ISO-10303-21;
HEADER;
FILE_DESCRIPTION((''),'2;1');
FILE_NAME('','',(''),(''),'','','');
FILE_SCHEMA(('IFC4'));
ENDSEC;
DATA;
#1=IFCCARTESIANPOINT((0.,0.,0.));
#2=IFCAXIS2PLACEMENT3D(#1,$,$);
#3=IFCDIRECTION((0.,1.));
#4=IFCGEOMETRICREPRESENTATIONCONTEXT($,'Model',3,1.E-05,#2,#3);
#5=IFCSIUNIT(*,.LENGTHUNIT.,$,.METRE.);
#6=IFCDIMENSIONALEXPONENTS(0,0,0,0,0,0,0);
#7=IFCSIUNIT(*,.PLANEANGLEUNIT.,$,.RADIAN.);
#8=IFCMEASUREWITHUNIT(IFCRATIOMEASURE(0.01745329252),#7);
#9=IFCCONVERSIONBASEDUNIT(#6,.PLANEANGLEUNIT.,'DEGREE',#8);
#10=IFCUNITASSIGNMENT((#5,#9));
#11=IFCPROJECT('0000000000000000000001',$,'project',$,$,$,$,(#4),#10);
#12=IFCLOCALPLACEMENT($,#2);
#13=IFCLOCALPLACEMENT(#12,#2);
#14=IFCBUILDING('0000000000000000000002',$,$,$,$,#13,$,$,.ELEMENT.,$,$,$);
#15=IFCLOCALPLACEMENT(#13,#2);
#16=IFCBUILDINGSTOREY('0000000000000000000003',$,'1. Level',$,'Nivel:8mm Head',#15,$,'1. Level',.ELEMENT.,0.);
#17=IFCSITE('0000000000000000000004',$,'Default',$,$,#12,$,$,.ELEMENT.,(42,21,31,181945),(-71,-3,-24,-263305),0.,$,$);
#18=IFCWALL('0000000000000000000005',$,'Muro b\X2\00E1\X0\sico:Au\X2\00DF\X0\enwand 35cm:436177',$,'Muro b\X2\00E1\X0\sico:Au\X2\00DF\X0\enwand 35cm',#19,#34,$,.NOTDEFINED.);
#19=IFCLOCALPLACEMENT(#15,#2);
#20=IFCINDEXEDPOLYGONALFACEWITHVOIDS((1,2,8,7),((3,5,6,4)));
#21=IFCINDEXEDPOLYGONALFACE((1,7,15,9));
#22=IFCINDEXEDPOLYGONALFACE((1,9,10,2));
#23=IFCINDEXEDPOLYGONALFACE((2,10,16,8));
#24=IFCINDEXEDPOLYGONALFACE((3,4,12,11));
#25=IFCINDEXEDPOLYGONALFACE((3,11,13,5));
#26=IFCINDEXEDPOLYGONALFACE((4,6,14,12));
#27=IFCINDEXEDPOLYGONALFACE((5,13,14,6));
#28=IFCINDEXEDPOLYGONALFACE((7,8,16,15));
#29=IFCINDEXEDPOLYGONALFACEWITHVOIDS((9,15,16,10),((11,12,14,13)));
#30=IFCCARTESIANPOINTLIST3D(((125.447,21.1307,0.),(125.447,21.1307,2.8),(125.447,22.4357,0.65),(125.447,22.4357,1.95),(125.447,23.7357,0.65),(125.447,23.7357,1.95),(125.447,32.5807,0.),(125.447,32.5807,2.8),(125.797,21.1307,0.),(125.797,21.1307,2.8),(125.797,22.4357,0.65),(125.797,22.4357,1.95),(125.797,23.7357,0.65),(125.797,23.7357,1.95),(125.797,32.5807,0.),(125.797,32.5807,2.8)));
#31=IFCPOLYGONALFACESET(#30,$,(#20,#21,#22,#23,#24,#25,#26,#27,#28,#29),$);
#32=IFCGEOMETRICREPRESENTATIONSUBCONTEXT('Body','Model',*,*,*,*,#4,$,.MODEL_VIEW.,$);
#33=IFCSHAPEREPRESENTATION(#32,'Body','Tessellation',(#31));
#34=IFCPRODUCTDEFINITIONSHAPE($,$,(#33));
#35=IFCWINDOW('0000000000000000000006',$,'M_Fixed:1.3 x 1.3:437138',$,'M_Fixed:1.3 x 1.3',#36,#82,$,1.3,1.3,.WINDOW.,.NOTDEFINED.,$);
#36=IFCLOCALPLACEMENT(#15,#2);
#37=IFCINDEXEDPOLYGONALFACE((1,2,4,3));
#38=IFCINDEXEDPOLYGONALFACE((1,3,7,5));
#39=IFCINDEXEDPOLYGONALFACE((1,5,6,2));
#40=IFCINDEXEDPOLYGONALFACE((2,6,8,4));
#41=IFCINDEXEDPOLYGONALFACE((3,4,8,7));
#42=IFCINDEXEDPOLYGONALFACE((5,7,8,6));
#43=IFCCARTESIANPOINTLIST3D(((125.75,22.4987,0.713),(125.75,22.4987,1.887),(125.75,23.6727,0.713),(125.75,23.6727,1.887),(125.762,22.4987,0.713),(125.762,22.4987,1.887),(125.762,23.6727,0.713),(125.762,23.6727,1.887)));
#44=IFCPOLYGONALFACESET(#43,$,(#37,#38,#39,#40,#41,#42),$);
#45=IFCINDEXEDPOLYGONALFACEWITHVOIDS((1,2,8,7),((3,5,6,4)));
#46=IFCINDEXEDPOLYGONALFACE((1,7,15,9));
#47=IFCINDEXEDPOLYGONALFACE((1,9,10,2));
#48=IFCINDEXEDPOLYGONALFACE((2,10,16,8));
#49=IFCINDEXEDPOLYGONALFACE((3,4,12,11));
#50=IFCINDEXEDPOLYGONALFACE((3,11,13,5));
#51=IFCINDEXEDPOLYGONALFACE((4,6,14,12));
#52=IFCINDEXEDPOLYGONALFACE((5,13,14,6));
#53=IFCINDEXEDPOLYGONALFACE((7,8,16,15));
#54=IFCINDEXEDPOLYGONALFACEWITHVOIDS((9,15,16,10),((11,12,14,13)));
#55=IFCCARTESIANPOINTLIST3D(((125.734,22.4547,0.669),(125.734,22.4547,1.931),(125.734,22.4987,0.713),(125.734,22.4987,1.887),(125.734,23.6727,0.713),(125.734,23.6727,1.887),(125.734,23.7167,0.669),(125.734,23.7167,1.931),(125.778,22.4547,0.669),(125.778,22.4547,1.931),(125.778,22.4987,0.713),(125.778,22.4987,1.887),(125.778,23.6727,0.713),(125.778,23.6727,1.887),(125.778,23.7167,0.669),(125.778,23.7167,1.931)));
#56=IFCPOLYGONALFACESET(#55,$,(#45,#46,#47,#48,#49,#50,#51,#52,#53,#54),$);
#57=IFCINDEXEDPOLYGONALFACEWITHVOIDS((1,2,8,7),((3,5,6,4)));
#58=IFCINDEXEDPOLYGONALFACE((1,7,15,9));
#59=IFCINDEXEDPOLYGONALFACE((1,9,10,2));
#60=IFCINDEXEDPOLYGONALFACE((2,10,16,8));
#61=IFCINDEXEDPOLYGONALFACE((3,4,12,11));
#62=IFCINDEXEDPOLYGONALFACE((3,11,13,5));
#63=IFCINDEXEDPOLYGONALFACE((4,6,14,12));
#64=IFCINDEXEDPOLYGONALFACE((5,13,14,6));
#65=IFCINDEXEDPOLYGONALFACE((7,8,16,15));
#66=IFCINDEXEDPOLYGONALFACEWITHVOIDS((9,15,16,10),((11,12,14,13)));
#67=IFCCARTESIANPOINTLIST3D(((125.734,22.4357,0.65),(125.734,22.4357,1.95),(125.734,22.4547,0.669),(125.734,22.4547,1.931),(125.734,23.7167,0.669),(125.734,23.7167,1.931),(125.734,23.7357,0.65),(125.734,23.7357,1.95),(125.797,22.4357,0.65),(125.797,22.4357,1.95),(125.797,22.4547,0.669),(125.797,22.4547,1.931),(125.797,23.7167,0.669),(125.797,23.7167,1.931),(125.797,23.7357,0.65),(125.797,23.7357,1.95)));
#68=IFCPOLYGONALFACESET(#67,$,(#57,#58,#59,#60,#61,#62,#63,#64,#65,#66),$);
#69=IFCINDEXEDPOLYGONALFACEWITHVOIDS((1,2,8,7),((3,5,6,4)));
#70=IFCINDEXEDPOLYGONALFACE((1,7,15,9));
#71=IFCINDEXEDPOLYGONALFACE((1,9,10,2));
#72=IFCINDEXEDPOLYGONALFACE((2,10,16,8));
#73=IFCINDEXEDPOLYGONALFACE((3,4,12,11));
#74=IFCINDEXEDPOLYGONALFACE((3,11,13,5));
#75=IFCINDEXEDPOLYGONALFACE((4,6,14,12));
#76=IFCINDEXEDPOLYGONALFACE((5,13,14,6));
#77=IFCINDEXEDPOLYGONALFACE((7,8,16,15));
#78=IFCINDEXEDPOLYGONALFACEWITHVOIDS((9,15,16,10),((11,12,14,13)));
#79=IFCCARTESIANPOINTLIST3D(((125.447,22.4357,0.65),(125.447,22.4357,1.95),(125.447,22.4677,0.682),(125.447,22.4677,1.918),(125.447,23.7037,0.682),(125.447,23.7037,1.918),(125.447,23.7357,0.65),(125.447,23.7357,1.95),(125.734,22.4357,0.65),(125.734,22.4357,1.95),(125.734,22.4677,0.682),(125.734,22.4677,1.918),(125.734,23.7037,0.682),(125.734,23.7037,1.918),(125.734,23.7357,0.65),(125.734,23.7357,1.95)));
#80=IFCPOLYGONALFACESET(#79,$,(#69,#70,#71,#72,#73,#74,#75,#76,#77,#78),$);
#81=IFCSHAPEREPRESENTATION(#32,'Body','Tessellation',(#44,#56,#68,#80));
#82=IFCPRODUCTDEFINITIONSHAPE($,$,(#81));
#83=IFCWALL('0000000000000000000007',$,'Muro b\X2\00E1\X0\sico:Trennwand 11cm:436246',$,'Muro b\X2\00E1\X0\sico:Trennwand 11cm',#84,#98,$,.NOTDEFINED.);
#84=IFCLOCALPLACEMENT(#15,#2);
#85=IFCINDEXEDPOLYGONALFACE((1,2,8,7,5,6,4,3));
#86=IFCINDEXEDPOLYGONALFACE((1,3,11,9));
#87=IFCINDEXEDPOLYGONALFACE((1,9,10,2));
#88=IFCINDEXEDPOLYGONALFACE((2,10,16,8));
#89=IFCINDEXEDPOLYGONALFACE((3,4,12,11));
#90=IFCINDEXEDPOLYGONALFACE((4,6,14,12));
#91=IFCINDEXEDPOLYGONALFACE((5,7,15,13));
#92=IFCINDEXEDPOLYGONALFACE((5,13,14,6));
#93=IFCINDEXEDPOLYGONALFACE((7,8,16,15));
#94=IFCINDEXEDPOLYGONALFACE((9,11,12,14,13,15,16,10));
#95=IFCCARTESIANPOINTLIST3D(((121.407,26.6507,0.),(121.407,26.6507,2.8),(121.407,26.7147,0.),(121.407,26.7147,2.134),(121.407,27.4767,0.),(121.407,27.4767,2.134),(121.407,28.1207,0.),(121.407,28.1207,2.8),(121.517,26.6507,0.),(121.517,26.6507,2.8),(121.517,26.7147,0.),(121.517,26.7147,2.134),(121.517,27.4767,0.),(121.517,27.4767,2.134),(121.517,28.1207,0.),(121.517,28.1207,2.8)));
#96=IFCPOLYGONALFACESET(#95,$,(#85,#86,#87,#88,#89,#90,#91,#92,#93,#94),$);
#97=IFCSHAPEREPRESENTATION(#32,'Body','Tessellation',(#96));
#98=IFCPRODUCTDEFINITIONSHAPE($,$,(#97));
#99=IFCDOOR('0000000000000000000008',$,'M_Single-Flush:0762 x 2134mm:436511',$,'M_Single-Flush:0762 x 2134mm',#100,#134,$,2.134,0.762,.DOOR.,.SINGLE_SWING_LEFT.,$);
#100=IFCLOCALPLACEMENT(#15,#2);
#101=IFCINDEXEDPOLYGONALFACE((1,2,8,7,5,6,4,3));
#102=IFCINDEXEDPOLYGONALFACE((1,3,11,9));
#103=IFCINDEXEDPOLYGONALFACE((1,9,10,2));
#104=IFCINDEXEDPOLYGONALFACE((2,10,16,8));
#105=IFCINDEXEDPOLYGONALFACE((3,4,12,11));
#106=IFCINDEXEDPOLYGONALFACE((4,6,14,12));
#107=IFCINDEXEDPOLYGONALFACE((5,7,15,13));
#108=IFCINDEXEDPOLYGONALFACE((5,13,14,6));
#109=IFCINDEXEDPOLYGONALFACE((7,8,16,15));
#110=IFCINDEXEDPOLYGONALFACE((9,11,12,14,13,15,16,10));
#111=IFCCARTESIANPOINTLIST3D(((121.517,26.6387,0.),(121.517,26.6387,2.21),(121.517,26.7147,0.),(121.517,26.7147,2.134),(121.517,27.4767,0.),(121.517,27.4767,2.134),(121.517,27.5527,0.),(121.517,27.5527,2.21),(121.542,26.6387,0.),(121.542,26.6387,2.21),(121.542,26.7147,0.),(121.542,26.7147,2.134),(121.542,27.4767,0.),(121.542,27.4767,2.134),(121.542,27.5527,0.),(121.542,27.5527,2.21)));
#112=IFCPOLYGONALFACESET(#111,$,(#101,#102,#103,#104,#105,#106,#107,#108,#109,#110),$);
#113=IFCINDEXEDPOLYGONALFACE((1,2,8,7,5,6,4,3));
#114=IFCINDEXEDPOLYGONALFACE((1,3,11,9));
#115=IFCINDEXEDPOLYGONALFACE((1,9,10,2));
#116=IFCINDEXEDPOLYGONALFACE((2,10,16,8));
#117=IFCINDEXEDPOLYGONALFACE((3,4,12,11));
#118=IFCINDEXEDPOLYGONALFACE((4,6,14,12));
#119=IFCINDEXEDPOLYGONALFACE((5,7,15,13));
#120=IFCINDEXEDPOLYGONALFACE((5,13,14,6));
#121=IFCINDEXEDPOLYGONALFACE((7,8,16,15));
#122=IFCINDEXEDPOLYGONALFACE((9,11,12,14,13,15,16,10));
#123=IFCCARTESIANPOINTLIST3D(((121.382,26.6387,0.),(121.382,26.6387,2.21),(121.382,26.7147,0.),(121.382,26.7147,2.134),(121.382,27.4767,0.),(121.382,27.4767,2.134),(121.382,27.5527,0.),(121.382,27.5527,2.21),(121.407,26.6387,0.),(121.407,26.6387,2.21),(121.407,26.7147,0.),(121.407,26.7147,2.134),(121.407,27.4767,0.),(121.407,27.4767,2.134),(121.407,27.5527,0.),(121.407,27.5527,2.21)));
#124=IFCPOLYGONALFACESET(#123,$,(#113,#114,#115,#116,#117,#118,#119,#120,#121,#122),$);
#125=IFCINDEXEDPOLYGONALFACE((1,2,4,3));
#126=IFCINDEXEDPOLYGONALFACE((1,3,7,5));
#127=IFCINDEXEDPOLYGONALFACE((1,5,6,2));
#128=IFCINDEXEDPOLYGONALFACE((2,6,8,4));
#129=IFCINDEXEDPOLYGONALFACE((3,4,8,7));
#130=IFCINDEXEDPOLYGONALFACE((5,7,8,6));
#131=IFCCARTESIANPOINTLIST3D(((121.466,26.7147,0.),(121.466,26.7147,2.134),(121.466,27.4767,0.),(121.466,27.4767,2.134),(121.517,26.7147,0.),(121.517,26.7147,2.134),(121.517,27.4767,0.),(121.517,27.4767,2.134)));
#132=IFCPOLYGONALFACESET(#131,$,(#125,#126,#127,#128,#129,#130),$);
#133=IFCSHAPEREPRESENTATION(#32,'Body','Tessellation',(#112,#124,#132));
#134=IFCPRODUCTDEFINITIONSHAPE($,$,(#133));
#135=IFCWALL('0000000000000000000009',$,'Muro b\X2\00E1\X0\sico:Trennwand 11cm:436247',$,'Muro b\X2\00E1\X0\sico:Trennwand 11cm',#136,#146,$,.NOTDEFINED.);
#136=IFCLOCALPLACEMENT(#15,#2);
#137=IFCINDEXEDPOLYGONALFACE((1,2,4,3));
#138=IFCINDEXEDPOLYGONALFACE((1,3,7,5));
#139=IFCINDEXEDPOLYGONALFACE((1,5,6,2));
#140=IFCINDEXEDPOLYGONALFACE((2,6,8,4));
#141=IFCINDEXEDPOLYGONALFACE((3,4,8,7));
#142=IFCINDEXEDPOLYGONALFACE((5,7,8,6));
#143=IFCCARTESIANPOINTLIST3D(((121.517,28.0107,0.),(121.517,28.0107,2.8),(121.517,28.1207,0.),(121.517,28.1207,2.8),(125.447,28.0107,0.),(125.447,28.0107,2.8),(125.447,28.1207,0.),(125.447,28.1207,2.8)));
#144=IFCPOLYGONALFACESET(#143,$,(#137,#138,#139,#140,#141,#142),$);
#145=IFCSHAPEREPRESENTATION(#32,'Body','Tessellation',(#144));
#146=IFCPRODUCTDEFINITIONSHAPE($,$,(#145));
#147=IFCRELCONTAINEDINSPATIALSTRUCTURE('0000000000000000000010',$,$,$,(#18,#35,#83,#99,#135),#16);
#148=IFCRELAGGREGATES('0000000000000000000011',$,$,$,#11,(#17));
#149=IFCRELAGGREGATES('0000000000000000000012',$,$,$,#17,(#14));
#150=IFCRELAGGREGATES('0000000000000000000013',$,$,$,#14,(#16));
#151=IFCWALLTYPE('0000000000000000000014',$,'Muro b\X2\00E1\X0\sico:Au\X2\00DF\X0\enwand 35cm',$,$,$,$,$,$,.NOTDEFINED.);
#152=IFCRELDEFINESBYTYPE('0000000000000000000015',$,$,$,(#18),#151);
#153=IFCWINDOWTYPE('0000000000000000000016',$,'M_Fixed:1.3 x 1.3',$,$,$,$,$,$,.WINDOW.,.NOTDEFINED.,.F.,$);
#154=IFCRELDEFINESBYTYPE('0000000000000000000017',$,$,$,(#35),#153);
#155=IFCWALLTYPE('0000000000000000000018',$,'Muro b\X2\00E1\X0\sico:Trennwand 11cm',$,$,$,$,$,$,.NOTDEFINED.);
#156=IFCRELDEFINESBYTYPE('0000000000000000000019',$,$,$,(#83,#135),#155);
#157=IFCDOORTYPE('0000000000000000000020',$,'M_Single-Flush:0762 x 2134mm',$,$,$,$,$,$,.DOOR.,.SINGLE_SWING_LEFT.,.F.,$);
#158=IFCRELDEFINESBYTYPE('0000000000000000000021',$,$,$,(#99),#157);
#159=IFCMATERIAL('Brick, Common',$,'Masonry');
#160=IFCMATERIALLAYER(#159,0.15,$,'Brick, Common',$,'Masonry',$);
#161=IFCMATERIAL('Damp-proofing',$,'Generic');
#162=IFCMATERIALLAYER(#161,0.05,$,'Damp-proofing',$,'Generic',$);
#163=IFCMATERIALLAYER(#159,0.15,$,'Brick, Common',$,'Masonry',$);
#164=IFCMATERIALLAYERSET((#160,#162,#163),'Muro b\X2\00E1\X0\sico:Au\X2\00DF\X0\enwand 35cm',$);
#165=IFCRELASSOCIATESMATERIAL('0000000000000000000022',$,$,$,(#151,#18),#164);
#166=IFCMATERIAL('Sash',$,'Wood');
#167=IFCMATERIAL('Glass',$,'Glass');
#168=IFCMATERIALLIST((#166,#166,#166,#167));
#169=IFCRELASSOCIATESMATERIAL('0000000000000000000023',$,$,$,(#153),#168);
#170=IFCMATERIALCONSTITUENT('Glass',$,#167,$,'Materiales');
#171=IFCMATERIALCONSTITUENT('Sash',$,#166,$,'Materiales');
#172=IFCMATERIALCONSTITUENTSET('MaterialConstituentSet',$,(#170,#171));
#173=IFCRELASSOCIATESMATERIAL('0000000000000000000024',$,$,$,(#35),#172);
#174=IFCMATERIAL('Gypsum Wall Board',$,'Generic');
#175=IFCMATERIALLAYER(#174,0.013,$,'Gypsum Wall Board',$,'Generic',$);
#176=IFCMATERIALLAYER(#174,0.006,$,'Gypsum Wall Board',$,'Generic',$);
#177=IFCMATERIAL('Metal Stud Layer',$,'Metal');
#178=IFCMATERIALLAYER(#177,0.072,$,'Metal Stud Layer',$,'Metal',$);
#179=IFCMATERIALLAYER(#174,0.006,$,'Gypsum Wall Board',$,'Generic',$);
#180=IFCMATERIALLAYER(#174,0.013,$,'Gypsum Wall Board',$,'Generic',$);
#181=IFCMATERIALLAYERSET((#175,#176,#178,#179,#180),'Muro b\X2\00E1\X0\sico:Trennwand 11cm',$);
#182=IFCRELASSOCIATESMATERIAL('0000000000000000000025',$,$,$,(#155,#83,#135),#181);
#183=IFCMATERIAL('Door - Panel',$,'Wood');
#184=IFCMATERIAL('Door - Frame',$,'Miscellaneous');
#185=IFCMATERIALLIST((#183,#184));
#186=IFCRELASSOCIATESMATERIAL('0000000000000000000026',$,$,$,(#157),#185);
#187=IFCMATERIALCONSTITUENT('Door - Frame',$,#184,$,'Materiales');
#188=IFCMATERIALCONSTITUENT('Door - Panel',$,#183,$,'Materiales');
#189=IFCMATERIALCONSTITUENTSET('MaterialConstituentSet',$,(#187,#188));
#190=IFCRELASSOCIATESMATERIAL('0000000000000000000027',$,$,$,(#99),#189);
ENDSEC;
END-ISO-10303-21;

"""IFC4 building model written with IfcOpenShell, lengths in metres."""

from ifc_helpers import new_model, entity, si_unit, converted_unit, direction, frame, frame_2d, origin, origin_2d_with_axis, place, context, subcontext, project, spatial, polyline, rectangle, outline, extrude, source, transform, mapped, material, material_list, layer, layer_set, layer_usage, constituent, constituent_set, type_object, type_shapes, element, fill, save


model = new_model("IFC4")

# Units and contexts
model_context = context("Model", 3, precision=1e-05, world=origin(), true_north=direction((0.0, 1.0)))
body_context = subcontext(model_context, "Body", "Model", "MODEL_VIEW")
ifc_project = project(units=[si_unit("LENGTHUNIT", "METRE"), converted_unit("PLANEANGLEUNIT", "DEGREE", entity("IfcRatioMeasure", 0.01745329252), si_unit("PLANEANGLEUNIT", "RADIAN"), dimensions=[0, 0, 0, 0, 0, 0, 0])], contexts=[model_context])

# Site, building, storey
site_placement = place(None, origin())
site = spatial("IfcSite", under=ifc_project, at=site_placement, Name="Default", CompositionType="ELEMENT", RefLatitude=(42, 21, 31, 181945), RefLongitude=(-71, -3, -24, -263305), RefElevation=0.0)
building_placement = place(site_placement, origin())
building = spatial("IfcBuilding", under=site, at=building_placement, CompositionType="ELEMENT")
storey_placement = place(building_placement, origin())
storey = spatial("IfcBuildingStorey", under=building, at=storey_placement, Name="1. Level", ObjectType="Nivel:8mm Head", LongName="1. Level", CompositionType="ELEMENT", Elevation=0.0)

# Wall, opening, window
ifc_material_1 = material(Name="Brick, Common", Category="Masonry")
ifc_layer_1 = layer(ifc_material_1, 0.15, Name="Brick, Common", Category="Masonry")
ifc_material_2 = material(Name="Damp-proofing", Category="Generic")
ifc_layer_2 = layer(ifc_material_2, 0.05, Name="Damp-proofing", Category="Generic")
ifc_layer_3 = layer(ifc_material_1, 0.15, Name="Brick, Common", Category="Masonry")
ifc_layer_set_1 = layer_set([ifc_layer_1, ifc_layer_2, ifc_layer_3], Name="Muro básico:Außenwand 35cm")
ifc_layer_usage_1 = layer_usage(ifc_layer_set_1, "AXIS2", "NEGATIVE", 0.175)
wall_type_1 = type_object("IfcWallType", Name="Muro básico:Außenwand 35cm", PredefinedType="NOTDEFINED", material=ifc_layer_set_1)
wall_1_placement = place(storey_placement, frame((125.622, 21.1307, 0.0), z_axis=(0.0, 0.0, 1.0), x_axis=(0.0, 1.0, 0.0)))
wall_1 = element("IfcWall", 1, at=wall_1_placement, inside=storey, type_object=wall_type_1, material=ifc_layer_usage_1, Name="Muro básico:Außenwand 35cm:436177", ObjectType="Muro básico:Außenwand 35cm", PredefinedType="NOTDEFINED", context=body_context, shape_type="SweptSolid", body=[
    extrude(rectangle(XDim=11.45, YDim=0.35, at=frame_2d((5.725, 0.0), x_axis=(-1.0, 0.0))), origin(), (0.0, 0.0, 1.0), 2.8),
])
opening_1_placement = place(wall_1_placement, frame((2.605, 0.175, 0.65)))
opening_1 = element("IfcOpeningElement", 2, at=opening_1_placement, cuts=wall_1, ObjectType="Opening", PredefinedType="OPENING", context=body_context, shape_type="SweptSolid", body=[
    extrude(rectangle(XDim=1.3, YDim=1.3, at=frame_2d((0.65, 0.65), x_axis=(1.0, 0.0))), frame((0.0, 0.0, 0.0), z_axis=(0.0, -1.0, 0.0), x_axis=(0.0, 0.0, 1.0)), (0.0, 0.0, 1.0), 0.35),
])
ifc_material_3 = material(Name="Glass", Category="Glass")
ifc_constituent_1 = constituent(ifc_material_3, Name="Glass", Category="Materiales")
ifc_material_4 = material(Name="Sash", Category="Wood")
ifc_constituent_2 = constituent(ifc_material_4, Name="Sash", Category="Materiales")
ifc_constituent_set_1 = constituent_set(constituents=[ifc_constituent_1, ifc_constituent_2], Name="MaterialConstituentSet")
ifc_material_list_1 = material_list([ifc_material_4, ifc_material_4, ifc_material_4, ifc_material_3])
window_type = type_object("IfcWindowType", Name="M_Fixed:1.3 x 1.3", ParameterTakesPrecedence=False, PartitioningType="NOTDEFINED", PredefinedType="WINDOW", material=ifc_material_list_1)
shared_shape_1 = source(origin(), body_context, "Body", "SweptSolid", [
    extrude(rectangle(XDim=0.012, YDim=1.174, at=origin_2d_with_axis()), frame((0.65, 0.309, 0.063), z_axis=(0.0, 0.0, 1.0), x_axis=(0.0, -1.0, 0.0)), (0.0, 0.0, 1.0), 1.174),
    extrude(outline(polyline([(-0.631, -0.631), (0.631, -0.631), (0.631, 0.631), (-0.631, 0.631), (-0.631, -0.631)]), holes=[polyline([(-0.587, -0.587), (-0.587, 0.587), (0.587, 0.587), (0.587, -0.587), (-0.587, -0.587)])]), frame((0.65, 0.287, 0.65), z_axis=(0.0, 1.0, 0.0), x_axis=(1.0, 0.0, 0.0)), (0.0, 0.0, 1.0), 0.044),
    extrude(outline(polyline([(-0.65, -0.65), (0.65, -0.65), (0.65, 0.65), (-0.65, 0.65), (-0.65, -0.65)]), holes=[polyline([(-0.631, -0.631), (-0.631, 0.631), (0.631, 0.631), (0.631, -0.631), (-0.631, -0.631)])]), frame((0.65, 0.287, 0.65), z_axis=(0.0, 1.0, 0.0), x_axis=(1.0, 0.0, 0.0)), (0.0, 0.0, 1.0), 0.063),
    extrude(outline(polyline([(-0.65, -0.65), (0.65, -0.65), (0.65, 0.65), (-0.65, 0.65), (-0.65, -0.65)]), holes=[polyline([(-0.618, -0.618), (-0.618, 0.618), (0.618, 0.618), (0.618, -0.618), (-0.618, -0.618)])]), frame((0.65, 0.0, 0.65), z_axis=(0.0, 1.0, 0.0), x_axis=(1.0, 0.0, 0.0)), (0.0, 0.0, 1.0), 0.287),
])
type_shapes(window_type, [shared_shape_1])
window_placement = place(opening_1_placement, frame((0.0, 0.0, 0.0), z_axis=(0.0, 0.0, 1.0), x_axis=(-1.0, 0.0, 0.0)))
window = element("IfcWindow", 3, at=window_placement, inside=storey, type_object=window_type, material=ifc_constituent_set_1, Name="M_Fixed:1.3 x 1.3:437138", ObjectType="M_Fixed:1.3 x 1.3", OverallHeight=1.3, OverallWidth=1.3, PartitioningType="NOTDEFINED", PredefinedType="WINDOW", context=body_context, shape_type="MappedRepresentation", body=[
    mapped(shared_shape_1, transform((0.0, 0.0, 0.0), scale=1.0)),
])
fill(opening_1, window)

# Wall, opening, door
ifc_material_5 = material(Name="Gypsum Wall Board", Category="Generic")
ifc_layer_4 = layer(ifc_material_5, 0.013, Name="Gypsum Wall Board", Category="Generic")
ifc_layer_5 = layer(ifc_material_5, 0.006, Name="Gypsum Wall Board", Category="Generic")
ifc_material_6 = material(Name="Metal Stud Layer", Category="Metal")
ifc_layer_6 = layer(ifc_material_6, 0.072, Name="Metal Stud Layer", Category="Metal")
ifc_layer_7 = layer(ifc_material_5, 0.006, Name="Gypsum Wall Board", Category="Generic")
ifc_layer_8 = layer(ifc_material_5, 0.013, Name="Gypsum Wall Board", Category="Generic")
ifc_layer_set_2 = layer_set([ifc_layer_4, ifc_layer_5, ifc_layer_6, ifc_layer_7, ifc_layer_8], Name="Muro básico:Trennwand 11cm")
ifc_layer_usage_2 = layer_usage(ifc_layer_set_2, "AXIS2", "NEGATIVE", 0.055)
wall_type_2 = type_object("IfcWallType", Name="Muro básico:Trennwand 11cm", PredefinedType="NOTDEFINED", material=ifc_layer_set_2)
wall_2_placement = place(storey_placement, frame((121.462, 26.6507, 0.0), z_axis=(0.0, 0.0, 1.0), x_axis=(0.0, 1.0, 0.0)))
wall_2 = element("IfcWall", 4, at=wall_2_placement, inside=storey, type_object=wall_type_2, material=ifc_layer_usage_2, Name="Muro básico:Trennwand 11cm:436246", ObjectType="Muro básico:Trennwand 11cm", PredefinedType="NOTDEFINED", context=body_context, shape_type="SweptSolid", body=[
    extrude(rectangle(XDim=1.47, YDim=0.11, at=frame_2d((0.735, 0.0), x_axis=(-1.0, 0.0))), origin(), (0.0, 0.0, 1.0), 2.8),
])
opening_2_placement = place(wall_2_placement, frame((0.826, 0.055, 0.0)))
opening_2 = element("IfcOpeningElement", 5, at=opening_2_placement, cuts=wall_2, ObjectType="Opening", PredefinedType="OPENING", context=body_context, shape_type="SweptSolid", body=[
    extrude(rectangle(XDim=0.762, YDim=2.134, at=frame_2d((1.067, 0.381), x_axis=(0.0, -1.0))), frame((0.0, 0.0, 0.0), z_axis=(0.0, -1.0, 0.0), x_axis=(0.0, 0.0, 1.0)), (0.0, 0.0, 1.0), 0.11),
])
ifc_material_7 = material(Name="Door - Frame", Category="Miscellaneous")
ifc_constituent_3 = constituent(ifc_material_7, Name="Door - Frame", Category="Materiales")
ifc_material_8 = material(Name="Door - Panel", Category="Wood")
ifc_constituent_4 = constituent(ifc_material_8, Name="Door - Panel", Category="Materiales")
ifc_constituent_set_2 = constituent_set(constituents=[ifc_constituent_3, ifc_constituent_4], Name="MaterialConstituentSet")
ifc_material_list_2 = material_list([ifc_material_8, ifc_material_7])
door_type_1 = type_object("IfcDoorType", Name="M_Single-Flush:0762 x 2134mm", OperationType="SINGLE_SWING_LEFT", ParameterTakesPrecedence=False, PredefinedType="DOOR", material=ifc_material_list_2)
shared_shape_2 = source(origin(), body_context, "Body", "SweptSolid", [
    extrude(outline(polyline([(-0.457, -1.124), (0.457, -1.124), (0.457, 1.086), (0.381, 1.086), (0.381, -1.048), (-0.381, -1.048), (-0.381, 1.086), (-0.457, 1.086), (-0.457, -1.124)])), frame((0.381, 0.135, 1.086), z_axis=(0.0, -1.0, 0.0), x_axis=(-1.0, 0.0, 0.0)), (0.0, 0.0, 1.0), 0.025),
    extrude(outline(polyline([(-1.124, -0.457), (1.086, -0.457), (1.086, -0.381), (-1.048, -0.381), (-1.048, 0.381), (1.086, 0.381), (1.086, 0.457), (-1.124, 0.457), (-1.124, -0.457)])), frame((0.381, 0.0, 1.086), z_axis=(0.0, -1.0, 0.0), x_axis=(0.0, 0.0, -1.0)), (0.0, 0.0, 1.0), 0.025),
    extrude(rectangle(XDim=0.762, YDim=0.051, at=origin_2d_with_axis()), frame((0.381, 0.0845, 0.0)), (0.0, 0.0, 1.0), 2.134),
])
type_shapes(door_type_1, [shared_shape_2])
door_1_placement = place(opening_2_placement, frame((0.0, 0.0, 0.0), z_axis=(0.0, 0.0, 1.0), x_axis=(-1.0, 0.0, 0.0)))
door_1 = element("IfcDoor", 6, at=door_1_placement, inside=storey, type_object=door_type_1, material=ifc_constituent_set_2, Name="M_Single-Flush:0762 x 2134mm:436511", ObjectType="M_Single-Flush:0762 x 2134mm", OperationType="SINGLE_SWING_LEFT", OverallHeight=2.134, OverallWidth=0.762, PredefinedType="DOOR", context=body_context, shape_type="MappedRepresentation", body=[
    mapped(shared_shape_2, transform((0.0, 0.0, 0.0), scale=1.0)),
])
fill(opening_2, door_1)

# Wall
ifc_layer_usage_3 = layer_usage(ifc_layer_set_2, "AXIS2", "NEGATIVE", 0.055)
wall_3_placement = place(storey_placement, frame((121.517, 28.0657, 0.0)))
element("IfcWall", 7, at=wall_3_placement, inside=storey, type_object=wall_type_2, material=ifc_layer_usage_3, Name="Muro básico:Trennwand 11cm:436247", ObjectType="Muro básico:Trennwand 11cm", PredefinedType="NOTDEFINED", context=body_context, shape_type="SweptSolid", body=[
    extrude(rectangle(XDim=3.93, YDim=0.11, at=frame_2d((1.965, 0.0), x_axis=(-1.0, 0.0))), origin(), (0.0, 0.0, 1.0), 2.8),
])

save(model, "model.ifc")
